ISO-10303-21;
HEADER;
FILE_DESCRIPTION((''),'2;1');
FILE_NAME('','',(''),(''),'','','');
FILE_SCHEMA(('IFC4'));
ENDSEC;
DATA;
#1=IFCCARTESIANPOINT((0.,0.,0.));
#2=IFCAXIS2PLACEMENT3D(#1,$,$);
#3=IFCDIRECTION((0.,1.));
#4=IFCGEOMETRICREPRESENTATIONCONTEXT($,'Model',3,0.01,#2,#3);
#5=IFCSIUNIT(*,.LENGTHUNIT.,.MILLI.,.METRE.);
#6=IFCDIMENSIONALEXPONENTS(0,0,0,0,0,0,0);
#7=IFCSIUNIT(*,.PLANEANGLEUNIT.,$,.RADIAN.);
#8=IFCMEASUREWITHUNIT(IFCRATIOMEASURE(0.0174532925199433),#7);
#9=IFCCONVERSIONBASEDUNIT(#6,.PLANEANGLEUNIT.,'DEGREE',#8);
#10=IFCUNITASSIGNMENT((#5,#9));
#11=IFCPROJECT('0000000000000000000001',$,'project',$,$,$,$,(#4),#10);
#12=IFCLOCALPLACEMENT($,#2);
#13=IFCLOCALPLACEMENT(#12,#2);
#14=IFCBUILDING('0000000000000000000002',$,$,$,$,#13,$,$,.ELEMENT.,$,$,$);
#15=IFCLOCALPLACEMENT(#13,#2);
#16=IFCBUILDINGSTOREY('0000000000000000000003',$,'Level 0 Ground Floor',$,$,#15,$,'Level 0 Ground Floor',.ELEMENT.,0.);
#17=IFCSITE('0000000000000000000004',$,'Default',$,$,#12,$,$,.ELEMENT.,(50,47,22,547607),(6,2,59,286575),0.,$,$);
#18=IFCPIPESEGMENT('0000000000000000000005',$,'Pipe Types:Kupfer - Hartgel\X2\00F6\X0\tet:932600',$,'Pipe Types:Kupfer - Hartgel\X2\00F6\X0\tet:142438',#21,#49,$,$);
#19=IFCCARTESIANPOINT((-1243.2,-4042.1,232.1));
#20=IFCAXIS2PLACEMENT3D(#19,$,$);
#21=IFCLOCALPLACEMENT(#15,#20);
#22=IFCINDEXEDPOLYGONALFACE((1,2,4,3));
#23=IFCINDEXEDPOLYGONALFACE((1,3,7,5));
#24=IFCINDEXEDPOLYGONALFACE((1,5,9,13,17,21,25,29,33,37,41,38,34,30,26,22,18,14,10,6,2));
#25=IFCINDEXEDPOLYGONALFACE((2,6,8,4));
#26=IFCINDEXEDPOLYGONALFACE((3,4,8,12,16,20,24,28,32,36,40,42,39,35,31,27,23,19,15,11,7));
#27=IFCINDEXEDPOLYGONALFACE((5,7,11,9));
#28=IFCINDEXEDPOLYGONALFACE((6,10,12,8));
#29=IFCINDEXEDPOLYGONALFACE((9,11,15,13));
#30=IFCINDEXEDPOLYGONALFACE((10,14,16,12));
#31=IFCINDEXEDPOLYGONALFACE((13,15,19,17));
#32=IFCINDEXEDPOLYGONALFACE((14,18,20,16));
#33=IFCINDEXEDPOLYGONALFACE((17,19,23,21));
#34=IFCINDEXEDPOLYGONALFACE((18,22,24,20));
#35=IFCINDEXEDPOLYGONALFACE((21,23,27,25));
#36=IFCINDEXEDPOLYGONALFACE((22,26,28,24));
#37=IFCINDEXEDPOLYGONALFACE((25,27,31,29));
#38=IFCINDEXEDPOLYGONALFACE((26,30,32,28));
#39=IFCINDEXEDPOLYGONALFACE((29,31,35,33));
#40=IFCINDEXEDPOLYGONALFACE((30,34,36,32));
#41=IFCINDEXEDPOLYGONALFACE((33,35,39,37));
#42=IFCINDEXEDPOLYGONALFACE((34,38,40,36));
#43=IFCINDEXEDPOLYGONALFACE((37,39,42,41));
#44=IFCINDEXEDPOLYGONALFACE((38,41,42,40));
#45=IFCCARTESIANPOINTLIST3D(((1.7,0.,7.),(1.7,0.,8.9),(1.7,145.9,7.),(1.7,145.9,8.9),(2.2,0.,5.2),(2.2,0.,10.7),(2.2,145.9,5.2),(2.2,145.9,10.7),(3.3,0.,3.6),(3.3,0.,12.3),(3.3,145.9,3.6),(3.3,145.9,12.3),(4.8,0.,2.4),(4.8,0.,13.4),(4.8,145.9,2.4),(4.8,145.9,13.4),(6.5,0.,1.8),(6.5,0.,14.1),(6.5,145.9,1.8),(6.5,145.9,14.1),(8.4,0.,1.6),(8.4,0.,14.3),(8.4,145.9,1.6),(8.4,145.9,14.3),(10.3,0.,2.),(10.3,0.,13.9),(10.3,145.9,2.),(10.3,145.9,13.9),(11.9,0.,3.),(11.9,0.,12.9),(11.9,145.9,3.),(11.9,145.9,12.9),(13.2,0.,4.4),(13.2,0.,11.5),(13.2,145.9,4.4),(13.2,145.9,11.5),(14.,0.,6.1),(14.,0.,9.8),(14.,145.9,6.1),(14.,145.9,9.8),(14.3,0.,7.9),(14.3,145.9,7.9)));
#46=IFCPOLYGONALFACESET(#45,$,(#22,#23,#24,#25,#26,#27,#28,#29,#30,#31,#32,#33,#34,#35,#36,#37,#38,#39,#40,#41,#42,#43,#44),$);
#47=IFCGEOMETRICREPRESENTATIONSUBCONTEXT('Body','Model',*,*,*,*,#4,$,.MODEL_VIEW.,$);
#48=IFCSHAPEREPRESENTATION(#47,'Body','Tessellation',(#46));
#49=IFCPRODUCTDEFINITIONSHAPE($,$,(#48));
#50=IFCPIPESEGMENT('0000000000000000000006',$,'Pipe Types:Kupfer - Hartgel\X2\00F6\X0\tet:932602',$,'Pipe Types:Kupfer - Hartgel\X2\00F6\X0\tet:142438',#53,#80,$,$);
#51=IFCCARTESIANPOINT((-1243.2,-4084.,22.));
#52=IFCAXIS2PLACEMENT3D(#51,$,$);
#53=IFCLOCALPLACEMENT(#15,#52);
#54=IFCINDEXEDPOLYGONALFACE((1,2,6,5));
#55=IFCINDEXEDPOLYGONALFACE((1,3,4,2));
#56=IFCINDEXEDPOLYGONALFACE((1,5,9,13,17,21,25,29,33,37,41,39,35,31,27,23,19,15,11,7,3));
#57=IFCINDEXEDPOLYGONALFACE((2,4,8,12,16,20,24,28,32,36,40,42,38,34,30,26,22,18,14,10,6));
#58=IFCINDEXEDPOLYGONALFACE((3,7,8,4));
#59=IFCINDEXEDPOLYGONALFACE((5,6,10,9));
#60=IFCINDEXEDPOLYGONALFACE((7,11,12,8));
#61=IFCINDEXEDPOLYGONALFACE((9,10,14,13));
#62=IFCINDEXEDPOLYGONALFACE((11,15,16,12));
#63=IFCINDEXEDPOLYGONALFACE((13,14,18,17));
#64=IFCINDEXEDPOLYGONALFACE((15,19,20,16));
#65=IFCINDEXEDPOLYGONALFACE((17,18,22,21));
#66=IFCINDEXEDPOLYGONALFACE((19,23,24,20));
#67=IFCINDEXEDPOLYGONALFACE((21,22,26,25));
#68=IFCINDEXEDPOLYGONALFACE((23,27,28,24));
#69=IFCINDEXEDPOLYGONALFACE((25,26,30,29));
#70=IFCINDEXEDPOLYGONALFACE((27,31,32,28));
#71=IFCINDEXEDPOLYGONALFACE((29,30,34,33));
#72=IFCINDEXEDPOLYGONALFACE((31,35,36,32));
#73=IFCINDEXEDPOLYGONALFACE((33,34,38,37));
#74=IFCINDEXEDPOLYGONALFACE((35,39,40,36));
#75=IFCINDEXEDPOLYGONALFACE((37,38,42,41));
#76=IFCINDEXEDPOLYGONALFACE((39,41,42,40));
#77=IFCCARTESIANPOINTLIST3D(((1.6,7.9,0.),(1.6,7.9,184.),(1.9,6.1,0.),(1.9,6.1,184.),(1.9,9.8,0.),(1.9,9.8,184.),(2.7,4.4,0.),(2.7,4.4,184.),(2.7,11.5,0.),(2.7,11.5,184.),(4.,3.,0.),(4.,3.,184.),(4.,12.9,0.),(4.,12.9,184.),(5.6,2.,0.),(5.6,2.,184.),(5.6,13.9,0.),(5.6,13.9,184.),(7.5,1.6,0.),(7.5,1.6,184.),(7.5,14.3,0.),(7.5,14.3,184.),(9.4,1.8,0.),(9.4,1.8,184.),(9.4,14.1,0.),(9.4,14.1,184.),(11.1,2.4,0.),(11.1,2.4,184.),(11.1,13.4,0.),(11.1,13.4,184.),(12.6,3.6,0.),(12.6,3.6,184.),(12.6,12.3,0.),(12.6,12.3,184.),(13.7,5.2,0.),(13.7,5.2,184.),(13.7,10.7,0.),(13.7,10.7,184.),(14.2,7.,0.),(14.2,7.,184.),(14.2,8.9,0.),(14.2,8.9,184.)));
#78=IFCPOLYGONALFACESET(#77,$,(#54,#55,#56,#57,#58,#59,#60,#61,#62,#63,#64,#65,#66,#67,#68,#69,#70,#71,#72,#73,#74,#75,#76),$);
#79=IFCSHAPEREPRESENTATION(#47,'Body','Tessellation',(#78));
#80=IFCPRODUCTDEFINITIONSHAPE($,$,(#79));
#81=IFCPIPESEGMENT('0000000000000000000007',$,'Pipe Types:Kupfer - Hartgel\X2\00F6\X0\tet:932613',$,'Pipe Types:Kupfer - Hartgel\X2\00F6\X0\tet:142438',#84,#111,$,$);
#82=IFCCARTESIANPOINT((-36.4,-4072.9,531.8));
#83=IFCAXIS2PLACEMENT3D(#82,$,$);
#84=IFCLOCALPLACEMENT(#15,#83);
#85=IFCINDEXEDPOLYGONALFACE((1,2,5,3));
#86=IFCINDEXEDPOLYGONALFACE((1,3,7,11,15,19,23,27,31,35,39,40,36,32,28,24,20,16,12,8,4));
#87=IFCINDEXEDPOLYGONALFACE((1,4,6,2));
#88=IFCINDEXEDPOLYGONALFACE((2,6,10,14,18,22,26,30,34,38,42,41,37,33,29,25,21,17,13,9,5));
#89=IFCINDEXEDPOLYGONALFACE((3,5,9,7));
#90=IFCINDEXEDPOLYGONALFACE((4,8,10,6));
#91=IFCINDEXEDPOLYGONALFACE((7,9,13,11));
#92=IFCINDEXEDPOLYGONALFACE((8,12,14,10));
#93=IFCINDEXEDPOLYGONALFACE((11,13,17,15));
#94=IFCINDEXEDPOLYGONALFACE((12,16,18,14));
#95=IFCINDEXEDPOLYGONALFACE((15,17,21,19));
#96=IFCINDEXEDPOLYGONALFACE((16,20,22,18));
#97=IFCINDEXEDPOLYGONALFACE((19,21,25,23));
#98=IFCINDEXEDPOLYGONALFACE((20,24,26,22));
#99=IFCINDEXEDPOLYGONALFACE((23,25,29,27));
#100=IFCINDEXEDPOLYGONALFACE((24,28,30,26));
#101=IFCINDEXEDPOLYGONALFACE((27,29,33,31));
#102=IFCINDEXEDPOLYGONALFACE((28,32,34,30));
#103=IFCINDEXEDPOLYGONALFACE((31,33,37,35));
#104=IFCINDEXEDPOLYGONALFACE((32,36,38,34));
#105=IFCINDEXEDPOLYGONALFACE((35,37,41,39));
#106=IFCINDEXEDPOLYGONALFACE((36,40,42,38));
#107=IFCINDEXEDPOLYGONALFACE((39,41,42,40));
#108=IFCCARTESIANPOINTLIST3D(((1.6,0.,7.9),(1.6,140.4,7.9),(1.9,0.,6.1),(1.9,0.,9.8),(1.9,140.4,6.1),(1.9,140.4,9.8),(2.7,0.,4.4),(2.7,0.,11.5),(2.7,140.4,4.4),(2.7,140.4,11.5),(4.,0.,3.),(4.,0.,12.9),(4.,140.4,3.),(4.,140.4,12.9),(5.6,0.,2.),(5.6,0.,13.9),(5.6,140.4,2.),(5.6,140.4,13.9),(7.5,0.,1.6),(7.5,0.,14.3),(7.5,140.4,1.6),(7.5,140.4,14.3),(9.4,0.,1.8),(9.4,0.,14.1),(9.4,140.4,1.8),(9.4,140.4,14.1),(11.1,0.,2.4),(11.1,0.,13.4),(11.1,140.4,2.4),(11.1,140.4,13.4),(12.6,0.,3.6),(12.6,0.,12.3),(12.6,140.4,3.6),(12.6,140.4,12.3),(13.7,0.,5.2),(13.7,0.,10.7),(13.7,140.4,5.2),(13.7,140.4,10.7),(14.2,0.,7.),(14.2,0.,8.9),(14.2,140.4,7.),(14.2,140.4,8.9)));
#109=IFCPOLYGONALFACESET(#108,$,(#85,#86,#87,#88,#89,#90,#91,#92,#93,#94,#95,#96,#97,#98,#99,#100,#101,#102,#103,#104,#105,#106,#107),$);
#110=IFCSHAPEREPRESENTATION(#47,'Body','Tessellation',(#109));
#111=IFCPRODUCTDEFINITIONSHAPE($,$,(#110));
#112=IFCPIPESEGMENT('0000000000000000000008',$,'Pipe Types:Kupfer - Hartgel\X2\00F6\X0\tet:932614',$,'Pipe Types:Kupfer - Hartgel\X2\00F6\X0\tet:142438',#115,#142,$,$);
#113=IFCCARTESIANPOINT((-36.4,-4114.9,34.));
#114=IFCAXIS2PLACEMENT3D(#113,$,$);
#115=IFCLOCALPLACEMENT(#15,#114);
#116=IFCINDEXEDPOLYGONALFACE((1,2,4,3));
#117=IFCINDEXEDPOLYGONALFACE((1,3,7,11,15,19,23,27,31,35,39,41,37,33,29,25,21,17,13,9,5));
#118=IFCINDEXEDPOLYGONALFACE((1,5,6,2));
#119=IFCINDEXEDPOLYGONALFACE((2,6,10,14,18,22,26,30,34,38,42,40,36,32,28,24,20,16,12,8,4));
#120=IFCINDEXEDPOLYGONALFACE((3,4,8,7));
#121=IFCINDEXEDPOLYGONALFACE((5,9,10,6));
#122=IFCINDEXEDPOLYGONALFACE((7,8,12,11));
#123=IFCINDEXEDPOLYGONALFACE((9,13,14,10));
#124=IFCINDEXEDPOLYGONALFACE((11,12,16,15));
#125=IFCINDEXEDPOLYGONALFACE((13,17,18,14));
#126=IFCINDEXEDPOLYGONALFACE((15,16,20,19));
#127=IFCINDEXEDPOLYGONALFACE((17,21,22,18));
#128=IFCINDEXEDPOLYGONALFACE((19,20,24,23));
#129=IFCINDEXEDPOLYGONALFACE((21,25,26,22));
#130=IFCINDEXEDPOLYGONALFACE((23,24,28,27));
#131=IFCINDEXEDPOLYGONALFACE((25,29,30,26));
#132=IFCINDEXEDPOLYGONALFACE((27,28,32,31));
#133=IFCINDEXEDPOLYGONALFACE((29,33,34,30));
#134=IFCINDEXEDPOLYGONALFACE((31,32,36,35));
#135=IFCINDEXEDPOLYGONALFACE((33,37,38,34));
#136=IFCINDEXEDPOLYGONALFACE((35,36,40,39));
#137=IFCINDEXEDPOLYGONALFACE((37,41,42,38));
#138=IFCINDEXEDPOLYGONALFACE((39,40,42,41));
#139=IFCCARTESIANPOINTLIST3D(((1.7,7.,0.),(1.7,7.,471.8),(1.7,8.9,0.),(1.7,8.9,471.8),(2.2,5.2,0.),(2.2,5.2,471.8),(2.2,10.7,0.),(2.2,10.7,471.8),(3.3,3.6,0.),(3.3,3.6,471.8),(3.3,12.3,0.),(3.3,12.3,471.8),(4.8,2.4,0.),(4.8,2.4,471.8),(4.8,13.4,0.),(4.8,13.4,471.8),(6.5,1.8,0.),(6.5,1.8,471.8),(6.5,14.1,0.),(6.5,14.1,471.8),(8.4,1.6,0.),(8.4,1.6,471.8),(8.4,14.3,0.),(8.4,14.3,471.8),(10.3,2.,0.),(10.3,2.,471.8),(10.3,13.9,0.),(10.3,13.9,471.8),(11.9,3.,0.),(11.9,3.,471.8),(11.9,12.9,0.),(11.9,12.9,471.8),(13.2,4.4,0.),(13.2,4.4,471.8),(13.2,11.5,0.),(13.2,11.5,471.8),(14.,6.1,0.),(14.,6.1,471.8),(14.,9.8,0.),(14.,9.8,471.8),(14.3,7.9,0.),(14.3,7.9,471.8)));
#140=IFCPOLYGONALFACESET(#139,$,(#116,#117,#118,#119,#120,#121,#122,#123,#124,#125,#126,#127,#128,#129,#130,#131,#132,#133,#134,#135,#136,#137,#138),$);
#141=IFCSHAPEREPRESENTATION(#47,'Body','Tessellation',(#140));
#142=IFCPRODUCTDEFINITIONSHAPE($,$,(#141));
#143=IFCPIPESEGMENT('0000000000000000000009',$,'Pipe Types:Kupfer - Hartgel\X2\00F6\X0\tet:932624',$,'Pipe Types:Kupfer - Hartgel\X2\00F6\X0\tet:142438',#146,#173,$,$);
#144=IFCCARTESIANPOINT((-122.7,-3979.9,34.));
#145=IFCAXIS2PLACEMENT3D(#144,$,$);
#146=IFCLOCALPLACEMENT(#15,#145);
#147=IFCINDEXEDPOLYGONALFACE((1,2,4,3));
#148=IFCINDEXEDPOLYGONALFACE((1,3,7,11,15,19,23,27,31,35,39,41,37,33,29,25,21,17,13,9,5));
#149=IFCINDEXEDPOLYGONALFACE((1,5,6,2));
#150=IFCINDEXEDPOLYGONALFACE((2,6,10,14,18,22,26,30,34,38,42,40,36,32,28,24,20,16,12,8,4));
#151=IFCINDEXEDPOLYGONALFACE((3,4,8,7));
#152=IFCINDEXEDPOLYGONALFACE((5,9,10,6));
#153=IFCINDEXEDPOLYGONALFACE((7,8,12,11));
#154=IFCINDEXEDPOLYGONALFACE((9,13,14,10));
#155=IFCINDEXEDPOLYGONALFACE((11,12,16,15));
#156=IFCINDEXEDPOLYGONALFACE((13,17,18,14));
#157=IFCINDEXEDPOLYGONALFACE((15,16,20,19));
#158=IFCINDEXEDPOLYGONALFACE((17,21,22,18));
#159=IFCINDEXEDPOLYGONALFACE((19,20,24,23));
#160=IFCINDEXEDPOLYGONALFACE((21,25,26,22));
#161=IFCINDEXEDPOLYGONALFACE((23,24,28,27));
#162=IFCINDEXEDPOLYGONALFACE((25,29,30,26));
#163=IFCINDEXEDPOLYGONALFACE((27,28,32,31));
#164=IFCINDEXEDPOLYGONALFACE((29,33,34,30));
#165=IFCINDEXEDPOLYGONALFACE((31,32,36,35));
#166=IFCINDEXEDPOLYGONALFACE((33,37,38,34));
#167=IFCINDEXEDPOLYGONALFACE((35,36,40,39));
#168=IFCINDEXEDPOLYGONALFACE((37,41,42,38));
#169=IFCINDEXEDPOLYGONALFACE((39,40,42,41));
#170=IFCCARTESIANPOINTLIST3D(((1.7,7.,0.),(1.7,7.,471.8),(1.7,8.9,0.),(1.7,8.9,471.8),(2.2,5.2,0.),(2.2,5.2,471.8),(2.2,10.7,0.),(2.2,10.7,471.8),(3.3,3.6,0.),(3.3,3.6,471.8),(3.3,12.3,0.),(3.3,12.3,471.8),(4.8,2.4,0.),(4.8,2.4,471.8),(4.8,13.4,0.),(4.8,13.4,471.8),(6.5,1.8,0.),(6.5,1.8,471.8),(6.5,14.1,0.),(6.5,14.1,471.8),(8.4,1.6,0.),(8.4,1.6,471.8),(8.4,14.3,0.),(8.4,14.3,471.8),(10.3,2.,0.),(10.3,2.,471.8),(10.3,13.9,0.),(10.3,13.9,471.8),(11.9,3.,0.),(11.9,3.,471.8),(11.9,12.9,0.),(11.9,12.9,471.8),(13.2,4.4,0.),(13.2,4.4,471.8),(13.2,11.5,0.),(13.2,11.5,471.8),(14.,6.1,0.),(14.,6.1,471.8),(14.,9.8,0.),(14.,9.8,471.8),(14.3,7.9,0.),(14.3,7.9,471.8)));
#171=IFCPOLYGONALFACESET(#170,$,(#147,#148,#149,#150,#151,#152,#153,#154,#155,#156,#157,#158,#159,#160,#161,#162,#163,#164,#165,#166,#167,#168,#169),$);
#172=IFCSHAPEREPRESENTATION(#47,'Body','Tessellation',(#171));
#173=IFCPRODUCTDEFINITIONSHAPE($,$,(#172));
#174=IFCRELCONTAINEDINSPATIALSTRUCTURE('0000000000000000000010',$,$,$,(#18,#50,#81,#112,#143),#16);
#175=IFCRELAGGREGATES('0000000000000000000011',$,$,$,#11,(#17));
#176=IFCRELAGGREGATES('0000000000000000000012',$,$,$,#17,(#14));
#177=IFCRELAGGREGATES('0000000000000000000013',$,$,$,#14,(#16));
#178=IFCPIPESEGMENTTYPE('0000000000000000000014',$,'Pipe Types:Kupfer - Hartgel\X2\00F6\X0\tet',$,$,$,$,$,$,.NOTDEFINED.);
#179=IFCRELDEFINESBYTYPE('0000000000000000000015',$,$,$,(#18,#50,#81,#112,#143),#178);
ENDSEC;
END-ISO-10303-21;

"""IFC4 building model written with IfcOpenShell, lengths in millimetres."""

from ifc_helpers import new_model, entity, si_unit, converted_unit, direction, frame, frame_2d, origin, origin_2d_with_axis, place, context, subcontext, project, spatial, circle, extrude, type_object, element, save


model = new_model("IFC4")

# Units and contexts
model_context = context("Model", 3, precision=0.01, world=origin(), true_north=direction((0.0, 1.0)))
body_context = subcontext(model_context, "Body", "Model", "MODEL_VIEW")
ifc_project = project(units=[si_unit("LENGTHUNIT", "METRE", prefix="MILLI"), converted_unit("PLANEANGLEUNIT", "DEGREE", entity("IfcRatioMeasure", 0.0174532925199433), si_unit("PLANEANGLEUNIT", "RADIAN"), dimensions=[0, 0, 0, 0, 0, 0, 0])], contexts=[model_context])

# Site, building, storey
site_placement = place(None, origin())
site = spatial("IfcSite", under=ifc_project, at=site_placement, Name="Default", CompositionType="ELEMENT", RefLatitude=(50, 47, 22, 547607), RefLongitude=(6, 2, 59, 286575), RefElevation=0.0)
building_placement = place(site_placement, origin())
building = spatial("IfcBuilding", under=site, at=building_placement, CompositionType="ELEMENT")
storey_placement = place(building_placement, origin())
storey = spatial("IfcBuildingStorey", under=building, at=storey_placement, Name="Level 0 Ground Floor", LongName="Level 0 Ground Floor", CompositionType="ELEMENT", Elevation=0.0)

# Pipe segments
pipe_segment_type_1 = type_object("IfcPipeSegmentType", Name="Pipe Types:Kupfer - Hartgelötet", PredefinedType="NOTDEFINED")
pipe_segment_1_placement = place(storey_placement, frame((-1243.2, -4042.1, 232.1)))
element("IfcPipeSegment", 1, at=pipe_segment_1_placement, inside=storey, type_object=pipe_segment_type_1, Name="Pipe Types:Kupfer - Hartgelötet:932600", ObjectType="Pipe Types:Kupfer - Hartgelötet:142438", context=body_context, shape_type="SweptSolid", body=[
    extrude(circle(Radius=6.3, at=frame_2d((0.0, 0.0), x_axis=(1.0, 0.0))), frame((7.9, 0.0, 7.9), z_axis=(0.0, 1.0, 0.0), x_axis=(1.0, 0.0, 0.0)), (0.0, 0.0, 1.0), 145.9),
])
pipe_segment_2_placement = place(storey_placement, frame((-1243.2, -4084.0, 22.0)))
element("IfcPipeSegment", 2, at=pipe_segment_2_placement, inside=storey, type_object=pipe_segment_type_1, Name="Pipe Types:Kupfer - Hartgelötet:932602", ObjectType="Pipe Types:Kupfer - Hartgelötet:142438", context=body_context, shape_type="SweptSolid", body=[
    extrude(circle(Radius=6.3, at=frame_2d((0.0, 0.0), x_axis=(1.0, 0.0))), frame((7.9, 7.9, 0.0), z_axis=(0.0, 0.0, 1.0), x_axis=(-1.0, 0.0, 0.0)), (0.0, 0.0, 1.0), 184.0),
])
pipe_segment_3_placement = place(storey_placement, frame((-36.4, -4072.9, 531.8)))
element("IfcPipeSegment", 3, at=pipe_segment_3_placement, inside=storey, type_object=pipe_segment_type_1, Name="Pipe Types:Kupfer - Hartgelötet:932613", ObjectType="Pipe Types:Kupfer - Hartgelötet:142438", context=body_context, shape_type="SweptSolid", body=[
    extrude(circle(Radius=6.3, at=frame_2d((0.0, 0.0), x_axis=(1.0, 0.0))), frame((7.9, 0.0, 7.9), z_axis=(0.0, 1.0, 0.0), x_axis=(-1.0, 0.0, 0.0)), (0.0, 0.0, 1.0), 140.4),
])
pipe_segment_4_placement = place(storey_placement, frame((-36.4, -4114.9, 34.0)))
element("IfcPipeSegment", 4, at=pipe_segment_4_placement, inside=storey, type_object=pipe_segment_type_1, Name="Pipe Types:Kupfer - Hartgelötet:932614", ObjectType="Pipe Types:Kupfer - Hartgelötet:142438", context=body_context, shape_type="SweptSolid", body=[
    extrude(circle(Radius=6.3, at=frame_2d((0.0, 0.0), x_axis=(1.0, 0.0))), frame((7.9, 7.9, 0.0)), (0.0, 0.0, 1.0), 471.8),
])
pipe_segment_5_placement = place(storey_placement, frame((-122.7, -3979.9, 34.0)))
element("IfcPipeSegment", 5, at=pipe_segment_5_placement, inside=storey, type_object=pipe_segment_type_1, Name="Pipe Types:Kupfer - Hartgelötet:932624", ObjectType="Pipe Types:Kupfer - Hartgelötet:142438", context=body_context, shape_type="SweptSolid", body=[
    extrude(circle(Radius=6.3, at=origin_2d_with_axis()), frame((7.9, 7.9, 0.0)), (0.0, 0.0, 1.0), 471.8),
])

save(model, "model.ifc")
